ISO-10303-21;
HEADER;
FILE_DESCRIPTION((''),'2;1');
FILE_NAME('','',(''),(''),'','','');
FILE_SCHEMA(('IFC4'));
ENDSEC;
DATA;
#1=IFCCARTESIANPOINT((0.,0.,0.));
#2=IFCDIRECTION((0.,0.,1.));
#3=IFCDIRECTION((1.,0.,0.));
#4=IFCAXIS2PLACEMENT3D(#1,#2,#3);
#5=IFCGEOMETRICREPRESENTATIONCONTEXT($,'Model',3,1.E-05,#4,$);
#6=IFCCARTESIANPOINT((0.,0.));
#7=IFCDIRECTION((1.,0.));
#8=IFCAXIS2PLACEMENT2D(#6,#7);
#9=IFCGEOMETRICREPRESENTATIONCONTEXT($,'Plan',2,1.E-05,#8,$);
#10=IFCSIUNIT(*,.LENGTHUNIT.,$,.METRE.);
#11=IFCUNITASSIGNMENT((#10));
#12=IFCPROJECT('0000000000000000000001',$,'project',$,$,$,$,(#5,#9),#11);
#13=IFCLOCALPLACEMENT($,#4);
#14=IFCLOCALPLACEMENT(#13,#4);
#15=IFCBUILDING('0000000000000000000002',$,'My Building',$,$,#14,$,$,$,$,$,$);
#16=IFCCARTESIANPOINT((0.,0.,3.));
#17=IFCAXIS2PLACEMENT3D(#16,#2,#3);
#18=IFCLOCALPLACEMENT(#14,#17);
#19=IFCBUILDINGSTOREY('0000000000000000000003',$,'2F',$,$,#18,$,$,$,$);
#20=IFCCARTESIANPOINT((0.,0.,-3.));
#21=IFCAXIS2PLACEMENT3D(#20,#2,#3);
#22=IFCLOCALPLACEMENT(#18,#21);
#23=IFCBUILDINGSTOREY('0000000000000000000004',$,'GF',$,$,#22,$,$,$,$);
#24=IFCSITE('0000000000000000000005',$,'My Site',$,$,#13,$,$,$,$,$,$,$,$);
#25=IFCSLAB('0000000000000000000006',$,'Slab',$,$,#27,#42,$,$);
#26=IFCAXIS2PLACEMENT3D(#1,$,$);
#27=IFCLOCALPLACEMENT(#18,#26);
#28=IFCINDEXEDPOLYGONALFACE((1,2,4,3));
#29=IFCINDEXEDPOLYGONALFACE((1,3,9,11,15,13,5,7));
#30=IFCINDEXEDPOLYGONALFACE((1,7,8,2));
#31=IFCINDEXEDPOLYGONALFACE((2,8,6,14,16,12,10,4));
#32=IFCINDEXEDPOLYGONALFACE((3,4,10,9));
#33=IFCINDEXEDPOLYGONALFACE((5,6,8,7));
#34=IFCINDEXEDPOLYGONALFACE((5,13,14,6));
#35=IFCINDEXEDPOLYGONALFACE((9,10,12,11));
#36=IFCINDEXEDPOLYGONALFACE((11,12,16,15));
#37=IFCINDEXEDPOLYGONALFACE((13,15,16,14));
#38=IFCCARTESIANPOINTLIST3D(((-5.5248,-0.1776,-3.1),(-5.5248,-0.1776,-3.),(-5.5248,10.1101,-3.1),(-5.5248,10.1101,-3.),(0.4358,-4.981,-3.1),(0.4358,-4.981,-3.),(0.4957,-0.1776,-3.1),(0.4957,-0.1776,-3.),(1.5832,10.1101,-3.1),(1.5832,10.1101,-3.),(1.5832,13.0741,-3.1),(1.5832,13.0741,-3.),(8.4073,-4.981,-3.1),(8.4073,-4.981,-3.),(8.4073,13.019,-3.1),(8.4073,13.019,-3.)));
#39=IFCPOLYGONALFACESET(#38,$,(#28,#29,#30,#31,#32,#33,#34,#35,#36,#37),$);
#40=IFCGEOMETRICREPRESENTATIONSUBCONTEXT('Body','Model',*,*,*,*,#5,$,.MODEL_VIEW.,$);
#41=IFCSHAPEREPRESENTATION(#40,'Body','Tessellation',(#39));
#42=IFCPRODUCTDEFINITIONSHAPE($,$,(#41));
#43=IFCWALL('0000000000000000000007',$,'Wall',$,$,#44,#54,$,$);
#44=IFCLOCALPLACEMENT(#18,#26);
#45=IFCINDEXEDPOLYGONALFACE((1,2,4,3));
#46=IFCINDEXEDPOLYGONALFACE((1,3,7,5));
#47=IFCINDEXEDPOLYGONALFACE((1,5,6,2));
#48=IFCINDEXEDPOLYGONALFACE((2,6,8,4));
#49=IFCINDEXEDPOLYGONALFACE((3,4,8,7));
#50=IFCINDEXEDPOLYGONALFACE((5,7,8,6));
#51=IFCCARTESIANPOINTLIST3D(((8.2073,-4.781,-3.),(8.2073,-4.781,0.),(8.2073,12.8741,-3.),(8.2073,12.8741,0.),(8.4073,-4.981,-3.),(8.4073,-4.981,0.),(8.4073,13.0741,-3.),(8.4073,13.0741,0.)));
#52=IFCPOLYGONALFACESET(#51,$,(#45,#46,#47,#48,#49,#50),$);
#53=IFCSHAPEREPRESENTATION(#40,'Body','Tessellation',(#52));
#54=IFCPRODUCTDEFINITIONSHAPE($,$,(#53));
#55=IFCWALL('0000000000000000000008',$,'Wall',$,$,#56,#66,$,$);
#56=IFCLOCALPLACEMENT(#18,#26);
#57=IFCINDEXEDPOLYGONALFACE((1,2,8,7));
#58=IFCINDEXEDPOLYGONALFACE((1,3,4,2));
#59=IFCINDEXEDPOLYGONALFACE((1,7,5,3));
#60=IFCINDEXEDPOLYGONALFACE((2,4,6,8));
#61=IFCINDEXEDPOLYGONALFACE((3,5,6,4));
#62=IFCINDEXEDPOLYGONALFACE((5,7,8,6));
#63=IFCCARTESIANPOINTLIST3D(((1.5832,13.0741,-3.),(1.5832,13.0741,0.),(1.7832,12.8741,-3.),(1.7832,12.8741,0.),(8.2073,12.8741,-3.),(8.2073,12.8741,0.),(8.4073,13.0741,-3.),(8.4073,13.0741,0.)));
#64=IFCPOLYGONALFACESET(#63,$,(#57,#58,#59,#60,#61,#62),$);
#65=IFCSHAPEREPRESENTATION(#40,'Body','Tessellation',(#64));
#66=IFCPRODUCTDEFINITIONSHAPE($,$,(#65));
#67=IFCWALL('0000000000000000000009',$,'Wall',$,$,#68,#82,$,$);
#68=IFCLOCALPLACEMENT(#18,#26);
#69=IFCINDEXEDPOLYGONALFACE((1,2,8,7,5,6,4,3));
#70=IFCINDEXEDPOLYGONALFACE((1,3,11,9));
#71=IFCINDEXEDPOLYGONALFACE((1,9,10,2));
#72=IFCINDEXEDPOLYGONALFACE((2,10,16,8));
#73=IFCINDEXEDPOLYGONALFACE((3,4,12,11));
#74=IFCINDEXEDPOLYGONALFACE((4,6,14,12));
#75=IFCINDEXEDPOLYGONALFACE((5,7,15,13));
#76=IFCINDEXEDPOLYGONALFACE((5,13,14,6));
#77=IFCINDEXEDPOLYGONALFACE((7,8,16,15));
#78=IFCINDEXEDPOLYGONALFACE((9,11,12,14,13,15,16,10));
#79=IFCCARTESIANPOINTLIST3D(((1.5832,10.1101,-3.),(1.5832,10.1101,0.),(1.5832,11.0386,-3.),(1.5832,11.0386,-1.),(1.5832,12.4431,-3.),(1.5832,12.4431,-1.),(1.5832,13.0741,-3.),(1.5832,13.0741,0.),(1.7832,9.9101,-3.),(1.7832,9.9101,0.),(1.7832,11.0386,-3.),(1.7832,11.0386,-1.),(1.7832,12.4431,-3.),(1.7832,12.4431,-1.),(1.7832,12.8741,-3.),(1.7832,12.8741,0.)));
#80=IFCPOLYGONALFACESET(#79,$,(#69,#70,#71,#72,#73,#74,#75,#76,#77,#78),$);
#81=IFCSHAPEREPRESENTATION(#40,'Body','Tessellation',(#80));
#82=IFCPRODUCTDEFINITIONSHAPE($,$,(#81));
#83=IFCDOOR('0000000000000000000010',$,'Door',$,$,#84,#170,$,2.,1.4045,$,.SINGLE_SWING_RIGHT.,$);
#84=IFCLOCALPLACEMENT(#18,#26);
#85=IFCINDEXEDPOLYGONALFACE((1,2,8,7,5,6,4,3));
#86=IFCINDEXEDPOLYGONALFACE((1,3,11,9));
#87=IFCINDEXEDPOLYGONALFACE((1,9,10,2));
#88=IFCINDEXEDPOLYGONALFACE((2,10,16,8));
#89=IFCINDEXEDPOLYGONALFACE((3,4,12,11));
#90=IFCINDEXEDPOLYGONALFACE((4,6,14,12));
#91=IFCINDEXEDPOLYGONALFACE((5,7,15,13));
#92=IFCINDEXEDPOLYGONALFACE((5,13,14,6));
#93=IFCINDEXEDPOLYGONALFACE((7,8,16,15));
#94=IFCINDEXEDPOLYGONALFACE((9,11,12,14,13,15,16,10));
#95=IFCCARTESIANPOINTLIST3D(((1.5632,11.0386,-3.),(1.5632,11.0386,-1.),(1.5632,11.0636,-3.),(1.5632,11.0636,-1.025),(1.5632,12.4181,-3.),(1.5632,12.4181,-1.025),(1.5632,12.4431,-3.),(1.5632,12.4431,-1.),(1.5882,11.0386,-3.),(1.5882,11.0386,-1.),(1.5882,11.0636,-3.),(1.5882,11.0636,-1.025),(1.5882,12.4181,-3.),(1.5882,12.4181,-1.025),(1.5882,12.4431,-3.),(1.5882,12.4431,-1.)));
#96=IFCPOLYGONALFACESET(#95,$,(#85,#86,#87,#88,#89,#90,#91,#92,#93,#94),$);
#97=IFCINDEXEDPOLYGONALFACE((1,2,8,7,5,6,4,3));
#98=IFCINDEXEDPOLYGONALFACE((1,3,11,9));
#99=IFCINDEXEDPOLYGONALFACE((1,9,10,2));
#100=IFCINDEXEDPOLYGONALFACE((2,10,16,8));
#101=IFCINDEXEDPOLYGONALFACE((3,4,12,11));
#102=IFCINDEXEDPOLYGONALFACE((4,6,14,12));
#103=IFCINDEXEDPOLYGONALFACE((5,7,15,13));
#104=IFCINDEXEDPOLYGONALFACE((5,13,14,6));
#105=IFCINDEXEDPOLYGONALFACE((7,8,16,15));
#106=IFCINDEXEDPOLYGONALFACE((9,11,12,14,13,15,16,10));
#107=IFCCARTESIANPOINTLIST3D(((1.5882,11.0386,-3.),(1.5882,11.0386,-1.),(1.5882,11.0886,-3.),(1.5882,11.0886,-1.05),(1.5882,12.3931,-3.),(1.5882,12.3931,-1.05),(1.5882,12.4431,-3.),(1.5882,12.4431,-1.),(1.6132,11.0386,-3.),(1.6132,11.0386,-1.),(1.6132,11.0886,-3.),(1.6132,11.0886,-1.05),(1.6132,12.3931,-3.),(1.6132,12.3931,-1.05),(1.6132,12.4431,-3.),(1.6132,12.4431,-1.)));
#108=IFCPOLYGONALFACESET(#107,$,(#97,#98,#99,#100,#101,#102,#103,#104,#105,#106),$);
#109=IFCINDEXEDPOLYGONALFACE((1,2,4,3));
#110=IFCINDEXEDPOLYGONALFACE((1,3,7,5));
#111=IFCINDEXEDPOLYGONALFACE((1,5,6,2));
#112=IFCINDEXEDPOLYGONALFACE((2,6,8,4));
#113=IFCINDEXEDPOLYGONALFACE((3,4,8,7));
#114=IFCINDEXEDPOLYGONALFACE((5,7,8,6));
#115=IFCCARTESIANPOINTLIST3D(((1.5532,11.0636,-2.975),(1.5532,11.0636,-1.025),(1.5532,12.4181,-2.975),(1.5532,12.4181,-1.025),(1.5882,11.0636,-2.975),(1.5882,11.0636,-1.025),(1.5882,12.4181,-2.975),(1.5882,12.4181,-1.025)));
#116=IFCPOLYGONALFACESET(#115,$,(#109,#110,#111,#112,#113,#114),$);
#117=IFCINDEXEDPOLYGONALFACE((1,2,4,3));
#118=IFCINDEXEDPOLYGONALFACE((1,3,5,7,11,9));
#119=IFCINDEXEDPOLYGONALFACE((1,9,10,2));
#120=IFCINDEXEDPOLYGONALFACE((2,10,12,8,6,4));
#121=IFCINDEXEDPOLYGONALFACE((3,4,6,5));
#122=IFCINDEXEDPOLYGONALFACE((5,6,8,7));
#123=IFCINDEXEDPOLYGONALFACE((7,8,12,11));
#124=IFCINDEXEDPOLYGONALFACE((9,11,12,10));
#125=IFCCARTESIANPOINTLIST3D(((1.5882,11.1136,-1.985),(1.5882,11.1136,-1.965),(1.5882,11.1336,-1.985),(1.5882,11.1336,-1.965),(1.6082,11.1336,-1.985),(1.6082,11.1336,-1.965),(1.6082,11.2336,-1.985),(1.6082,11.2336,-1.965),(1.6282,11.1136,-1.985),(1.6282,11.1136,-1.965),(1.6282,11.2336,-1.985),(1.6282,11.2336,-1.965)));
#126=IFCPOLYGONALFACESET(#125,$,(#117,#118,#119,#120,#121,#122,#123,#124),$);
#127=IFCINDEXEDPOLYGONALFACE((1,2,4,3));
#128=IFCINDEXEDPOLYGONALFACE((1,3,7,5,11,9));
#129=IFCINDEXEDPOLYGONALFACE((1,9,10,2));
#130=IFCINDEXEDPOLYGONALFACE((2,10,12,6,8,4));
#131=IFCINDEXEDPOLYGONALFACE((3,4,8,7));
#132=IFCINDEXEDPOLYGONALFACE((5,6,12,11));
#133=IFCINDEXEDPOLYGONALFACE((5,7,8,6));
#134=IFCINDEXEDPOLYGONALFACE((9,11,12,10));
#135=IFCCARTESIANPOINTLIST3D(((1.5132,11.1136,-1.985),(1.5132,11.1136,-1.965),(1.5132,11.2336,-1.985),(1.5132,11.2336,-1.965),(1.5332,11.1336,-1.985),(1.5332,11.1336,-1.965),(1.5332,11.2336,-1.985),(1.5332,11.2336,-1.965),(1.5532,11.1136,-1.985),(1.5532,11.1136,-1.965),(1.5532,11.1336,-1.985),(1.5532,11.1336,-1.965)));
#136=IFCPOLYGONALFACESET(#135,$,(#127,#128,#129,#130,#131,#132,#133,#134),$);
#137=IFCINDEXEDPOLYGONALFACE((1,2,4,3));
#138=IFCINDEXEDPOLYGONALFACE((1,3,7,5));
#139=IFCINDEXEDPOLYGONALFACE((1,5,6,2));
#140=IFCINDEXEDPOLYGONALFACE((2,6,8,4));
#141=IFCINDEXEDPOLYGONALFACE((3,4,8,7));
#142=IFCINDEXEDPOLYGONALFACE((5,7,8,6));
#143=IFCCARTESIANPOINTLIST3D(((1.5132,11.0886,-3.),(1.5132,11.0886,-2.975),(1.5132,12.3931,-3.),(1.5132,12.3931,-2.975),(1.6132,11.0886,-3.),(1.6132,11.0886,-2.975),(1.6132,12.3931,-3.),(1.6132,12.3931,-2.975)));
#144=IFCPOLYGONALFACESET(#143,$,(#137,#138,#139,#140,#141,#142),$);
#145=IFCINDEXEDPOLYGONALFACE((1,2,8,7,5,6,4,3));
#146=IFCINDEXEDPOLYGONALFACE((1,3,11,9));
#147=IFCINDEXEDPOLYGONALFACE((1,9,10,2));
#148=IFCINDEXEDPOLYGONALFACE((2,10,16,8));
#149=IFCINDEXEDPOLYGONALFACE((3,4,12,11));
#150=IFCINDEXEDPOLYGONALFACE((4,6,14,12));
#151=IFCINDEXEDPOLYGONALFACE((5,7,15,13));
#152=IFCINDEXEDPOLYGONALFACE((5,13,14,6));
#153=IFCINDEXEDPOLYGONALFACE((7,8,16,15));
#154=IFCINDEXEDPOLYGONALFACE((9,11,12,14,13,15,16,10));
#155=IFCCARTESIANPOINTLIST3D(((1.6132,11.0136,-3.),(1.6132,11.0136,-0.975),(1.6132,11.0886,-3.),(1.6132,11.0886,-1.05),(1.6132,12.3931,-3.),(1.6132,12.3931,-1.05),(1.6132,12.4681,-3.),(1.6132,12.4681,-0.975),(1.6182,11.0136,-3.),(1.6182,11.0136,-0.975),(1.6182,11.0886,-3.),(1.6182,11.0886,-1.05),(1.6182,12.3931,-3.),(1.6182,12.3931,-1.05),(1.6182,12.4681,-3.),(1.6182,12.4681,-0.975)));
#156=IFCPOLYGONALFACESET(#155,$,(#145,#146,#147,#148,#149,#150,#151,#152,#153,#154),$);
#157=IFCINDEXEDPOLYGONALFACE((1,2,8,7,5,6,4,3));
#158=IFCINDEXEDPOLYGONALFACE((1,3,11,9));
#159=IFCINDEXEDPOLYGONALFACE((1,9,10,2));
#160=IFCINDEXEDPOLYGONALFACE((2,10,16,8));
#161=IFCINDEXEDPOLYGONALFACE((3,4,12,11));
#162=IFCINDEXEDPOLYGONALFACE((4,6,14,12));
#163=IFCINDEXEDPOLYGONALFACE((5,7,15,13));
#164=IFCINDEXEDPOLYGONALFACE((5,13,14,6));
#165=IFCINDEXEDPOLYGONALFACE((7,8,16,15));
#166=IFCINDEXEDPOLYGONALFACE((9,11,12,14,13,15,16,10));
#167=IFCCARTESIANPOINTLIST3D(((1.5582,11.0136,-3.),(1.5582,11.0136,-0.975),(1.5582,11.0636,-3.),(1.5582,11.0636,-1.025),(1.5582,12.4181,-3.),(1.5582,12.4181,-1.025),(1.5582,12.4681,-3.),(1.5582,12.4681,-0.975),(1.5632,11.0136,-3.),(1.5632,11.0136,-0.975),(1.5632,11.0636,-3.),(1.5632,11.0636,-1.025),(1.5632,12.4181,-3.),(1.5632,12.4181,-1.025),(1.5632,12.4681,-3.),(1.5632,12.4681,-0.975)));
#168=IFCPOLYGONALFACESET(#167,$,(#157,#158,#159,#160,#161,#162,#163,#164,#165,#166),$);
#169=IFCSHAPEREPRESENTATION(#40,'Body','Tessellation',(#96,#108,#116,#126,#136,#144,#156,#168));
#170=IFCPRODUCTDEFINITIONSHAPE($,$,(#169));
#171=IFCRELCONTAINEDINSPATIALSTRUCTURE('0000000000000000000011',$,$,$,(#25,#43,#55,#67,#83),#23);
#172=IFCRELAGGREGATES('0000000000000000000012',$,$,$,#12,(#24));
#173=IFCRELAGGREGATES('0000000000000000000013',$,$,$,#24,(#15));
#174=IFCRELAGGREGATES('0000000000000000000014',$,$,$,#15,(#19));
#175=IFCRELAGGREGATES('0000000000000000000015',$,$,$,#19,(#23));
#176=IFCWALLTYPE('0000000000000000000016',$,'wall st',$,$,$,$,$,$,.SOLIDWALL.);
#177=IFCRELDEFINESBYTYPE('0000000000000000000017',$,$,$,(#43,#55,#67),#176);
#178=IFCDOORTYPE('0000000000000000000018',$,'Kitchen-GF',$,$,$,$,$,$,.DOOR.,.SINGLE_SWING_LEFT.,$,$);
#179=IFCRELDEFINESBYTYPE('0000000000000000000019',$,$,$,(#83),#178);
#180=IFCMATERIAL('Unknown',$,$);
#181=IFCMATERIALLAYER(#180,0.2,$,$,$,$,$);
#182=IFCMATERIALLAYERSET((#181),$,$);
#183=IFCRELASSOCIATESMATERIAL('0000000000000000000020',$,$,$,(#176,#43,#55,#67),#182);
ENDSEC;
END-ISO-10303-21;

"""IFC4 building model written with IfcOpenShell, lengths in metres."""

from ifc_helpers import new_model, entity, si_unit, frame, origin_with_axes, origin_2d_with_axis, place, context, subcontext, project, spatial, line, indexed_curve, outline, extrude, shape, source, transform, mapped, material, layer, layer_set, layer_usage, type_object, type_shapes, element, fill, save


model = new_model("IFC4")

# Units and contexts
model_context = context("Model", 3, precision=1e-05, world=origin_with_axes())
plan_context = context("Plan", 2, precision=1e-05, world=origin_2d_with_axis())
body_context_1 = subcontext(model_context, "Body", "Model", "MODEL_VIEW")
body_context_2 = subcontext(plan_context, "Body", "Plan", "PLAN_VIEW")
ifc_project = project(units=[si_unit("LENGTHUNIT", "METRE")], contexts=[model_context, plan_context])

# Site, building, storeys
site_placement = place(None, origin_with_axes())
site = spatial("IfcSite", under=ifc_project, at=site_placement, Name="My Site")
building_placement = place(site_placement, origin_with_axes())
building = spatial("IfcBuilding", under=site, at=building_placement, Name="My Building")
storey_1_placement = place(building_placement, frame((0.0, 0.0, 3.0), z_axis=(0.0, 0.0, 1.0), x_axis=(1.0, 0.0, 0.0)))
storey_1 = spatial("IfcBuildingStorey", under=building, at=storey_1_placement, Name="2F")
storey_2_placement = place(storey_1_placement, frame((0.0, 0.0, -3.0), z_axis=(0.0, 0.0, 1.0), x_axis=(1.0, 0.0, 0.0)))
storey_2 = spatial("IfcBuildingStorey", under=storey_1, at=storey_2_placement, Name="GF")

# Slab
ifc_material = material(Name="Unknown")
slab_1_placement = place(storey_2_placement, frame((8.4073, -4.981, 0.0), z_axis=(0.0, 0.0, 1.0), x_axis=(1.0, 0.0, 0.0)))
element("IfcSlab", 1, at=slab_1_placement, inside=storey_2, Name="Slab", context=body_context_1, shape_type="SweptSolid", body=[
    extrude(outline(indexed_curve([(0.0, 0.0), (0.0, 18.0), (-6.8241, 18.055), (-6.8241, 15.091), (-13.9321, 15.091), (-13.9321, 4.8033), (-7.9116, 4.8033), (-7.9715, 0.0), (0.0, 0.0)])), frame((0.0, 0.0, -0.1), z_axis=(0.0, 0.0, 1.0), x_axis=(1.0, 0.0, 0.0)), (0.0, 0.0, 1.0), 0.1),
])

# Shared definitions
ifc_layer_1 = layer(ifc_material, 0.2)
ifc_layer_set_1 = layer_set([ifc_layer_1])
wall_type = type_object("IfcWallType", Name="wall st", PredefinedType="SOLIDWALL", material=ifc_layer_set_1)

# Walls
ifc_layer_usage_1 = layer_usage(ifc_layer_set_1, "AXIS2", "POSITIVE", 0.0)
wall_1_placement = place(storey_2_placement, frame((8.4073, -4.981, 0.0), z_axis=(0.0, 0.0, 1.0), x_axis=(0.0, 1.0, 0.0)))
element("IfcWall", 2, at=wall_1_placement, inside=storey_2, type_object=wall_type, material=ifc_layer_usage_1, Name="Wall", context=body_context_1, shape_type="SweptSolid", body=[
    extrude(outline(indexed_curve([(0.0, 0.0), (0.2, 0.2), (17.855, 0.2), (18.055, 0.0)], segments=[line(1, 2, 3, 4, 1)])), origin_with_axes(), (0.0, 0.0, 1.0), 3.0),
])
ifc_layer_usage_2 = layer_usage(ifc_layer_set_1, "AXIS2", "POSITIVE", 0.0)
wall_2_placement = place(storey_2_placement, frame((8.4073, 13.0741, 0.0), z_axis=(0.0, 0.0, 1.0), x_axis=(-1.0, 0.0, 0.0)))
element("IfcWall", 3, at=wall_2_placement, inside=storey_2, type_object=wall_type, material=ifc_layer_usage_2, Name="Wall", context=body_context_1, shape_type="SweptSolid", body=[
    extrude(outline(indexed_curve([(0.0, 0.0), (0.2, 0.2), (6.6241, 0.2), (6.8241, 0.0)], segments=[line(1, 2, 3, 4, 1)])), origin_with_axes(), (0.0, 0.0, 1.0), 3.0),
])

# Wall, opening, door
ifc_layer_usage_3 = layer_usage(ifc_layer_set_1, "AXIS2", "POSITIVE", 0.0)
wall_3_placement = place(storey_2_placement, frame((1.5832, 13.0741, 0.0), z_axis=(0.0, 0.0, 1.0), x_axis=(0.0, -1.0, 0.0)))
wall_3 = element("IfcWall", 4, at=wall_3_placement, inside=storey_2, type_object=wall_type, material=ifc_layer_usage_3, Name="Wall", context=body_context_1, shape_type="SweptSolid", body=[
    extrude(outline(indexed_curve([(0.0, 0.0), (0.2, 0.2), (3.164, 0.2), (2.964, 0.0)], segments=[line(1, 2, 3, 4, 1)])), origin_with_axes(), (0.0, 0.0, 1.0), 3.0),
])
shared_shape_1 = source(origin_with_axes(), body_context_1, "Body", "SweptSolid", [
    extrude(outline(indexed_curve([(0.0, 0.0), (1.4045, 0.0), (1.4045, 2.0), (0.0, 2.0)], segments=[line(1, 2, 3, 4, 1)])), frame((0.0, -0.6, 0.0), z_axis=(0.0, -1.0, 0.0), x_axis=(1.0, 0.0, 0.0)), (0.0, 0.0, -1.0), 1.2),
])
opening_1_placement = place(wall_3_placement, frame((2.0355, 0.03, 0.0), z_axis=(0.0, 0.0, 1.0), x_axis=(-1.0, 0.0, 0.0)))
opening_1 = element("IfcOpeningElement", 5, at=opening_1_placement, cuts=wall_3, PredefinedType="OPENING", context=body_context_1, shape_type="MappedRepresentation", body=[
    mapped(shared_shape_1, transform((0.0, 0.0, 0.0), x_axis=(1.0, 0.0, 0.0), y_axis=(0.0, 1.0, 0.0), z_axis=(0.0, 0.0, 1.0), scale=1.0)),
])
door_type_1 = type_object("IfcDoorType", Name="Kitchen-GF", OperationType="SINGLE_SWING_LEFT", PredefinedType="DOOR")
shared_shape_2 = source(origin_with_axes(), body_context_1, "Body", "SweptSolid", [
    extrude(outline(indexed_curve([(0.0, 0.0), (0.0, 2.0), (1.4045, 2.0), (1.4045, 0.0), (1.3795, 0.0), (1.3795, 1.975), (0.025, 1.975), (0.025, 0.0)], segments=[line(1, 2, 3, 4, 5, 6, 7, 8, 1)])), frame((0.0, 0.025, 0.0), z_axis=(0.0, -1.0, 0.0), x_axis=(1.0, 0.0, 0.0)), (0.0, 0.0, -1.0), 0.025),
    extrude(outline(indexed_curve([(0.0, 0.0), (0.0, 2.0), (1.4045, 2.0), (1.4045, 0.0), (1.3545, 0.0), (1.3545, 1.95), (0.05, 1.95), (0.05, 0.0)], segments=[line(1, 2, 3, 4, 5, 6, 7, 8, 1)])), frame((0.0, 0.0, 0.0), z_axis=(0.0, -1.0, 0.0), x_axis=(1.0, 0.0, 0.0)), (0.0, 0.0, -1.0), 0.025),
    extrude(outline(indexed_curve([(0.0, 0.0), (1.3545, 0.0), (1.3545, 0.035), (0.0, 0.035)], segments=[line(1, 2, 3, 4, 1)])), frame((0.025, 0.025, 0.025), z_axis=(0.0, 0.0, 1.0), x_axis=(1.0, 0.0, 0.0)), (0.0, 0.0, 1.0), 1.95),
    extrude(outline(indexed_curve([(0.0, 0.0), (0.0, -0.04), (0.12, -0.04), (0.12, -0.02), (0.02, -0.02), (0.02, 0.0)], segments=[line(1, 2, 3, 4, 5, 6, 1)])), frame((0.075, 0.025, 1.015), z_axis=(0.0, 0.0, 1.0), x_axis=(1.0, 0.0, 0.0)), (0.0, 0.0, 1.0), 0.02),
    extrude(outline(indexed_curve([(0.0, 0.0), (0.0, 0.04), (0.12, 0.04), (0.12, 0.02), (0.02, 0.02), (0.02, 0.0)], segments=[line(1, 2, 3, 4, 5, 6, 1)])), frame((0.075, 0.06, 1.015), z_axis=(0.0, 0.0, 1.0), x_axis=(1.0, 0.0, 0.0)), (0.0, 0.0, 1.0), 0.02),
    extrude(outline(indexed_curve([(0.0, 0.0), (1.3045, 0.0), (1.3045, 0.1), (0.0, 0.1)], segments=[line(1, 2, 3, 4, 1)])), frame((0.05, 0.0, 0.0), z_axis=(0.0, 0.0, 1.0), x_axis=(1.0, 0.0, 0.0)), (0.0, 0.0, 1.0), 0.025),
    extrude(outline(indexed_curve([(0.0, 0.0), (0.0, 2.025), (1.4545, 2.025), (1.4545, 0.0), (1.3795, 0.0), (1.3795, 1.95), (0.075, 1.95), (0.075, 0.0)], segments=[line(1, 2, 3, 4, 5, 6, 7, 8, 1)])), frame((-0.025, -0.005, 0.0), z_axis=(0.0, -1.0, 0.0), x_axis=(1.0, 0.0, 0.0)), (0.0, 0.0, -1.0), 0.005),
    extrude(outline(indexed_curve([(0.0, 0.0), (0.0, 2.025), (1.4545, 2.025), (1.4545, 0.0), (1.4045, 0.0), (1.4045, 1.975), (0.05, 1.975), (0.05, 0.0)], segments=[line(1, 2, 3, 4, 5, 6, 7, 8, 1)])), frame((-0.025, 0.05, 0.0), z_axis=(0.0, -1.0, 0.0), x_axis=(1.0, 0.0, 0.0)), (0.0, 0.0, -1.0), 0.005),
])
shared_shape_3 = source(origin_with_axes(), body_context_2, "Body", "Curve2D", [
    entity("IfcIndexedPolyCurve", entity("IfcCartesianPointList2D", [[0.0, 0.0], [0.0, 0.05], [0.025, 0.05], [0.025, 0.025], [0.05, 0.025], [0.05, 0.0]]), [entity("IfcLineIndex", [1, 2, 3, 4, 5, 6, 1])]),
    entity("IfcIndexedPolyCurve", entity("IfcCartesianPointList2D", [[1.4045, 0.0], [1.4045, 0.05], [1.3795, 0.05], [1.3795, 0.025], [1.3545, 0.025], [1.3545, 0.0]]), [entity("IfcLineIndex", [1, 2, 3, 4, 5, 6, 1])]),
    entity("IfcTrimmedCurve", entity("IfcEllipse", entity("IfcAxis2Placement2D", entity("IfcCartesianPoint", [1.3445, 0.05]), entity("IfcDirection", [1.0, 0.0])), 1.3195, 1.3545), [entity("IfcCartesianPoint", [1.3445, 1.4045])], [entity("IfcCartesianPoint", [0.025, 0.05])], True, "CARTESIAN"),
    entity("IfcIndexedPolyCurve", entity("IfcCartesianPointList2D", [[1.3795, 0.05], [1.3445, 0.05], [1.3445, 1.4045], [1.3795, 1.4045]]), [entity("IfcLineIndex", [1, 2, 3, 4, 1])]),
])
type_shapes(door_type_1, [shared_shape_2, shared_shape_3])
door_1_placement = place(opening_1_placement, frame((0.0, 0.0, 0.0), z_axis=(0.0, 0.0, 1.0), x_axis=(1.0, 0.0, 0.0)))
door_1 = element("IfcDoor", 6, at=door_1_placement, inside=storey_2, type_object=door_type_1, Name="Door", OperationType="SINGLE_SWING_RIGHT", OverallHeight=2.0, OverallWidth=1.4045, shapes=[
    shape(body_context_1, "Body", "MappedRepresentation", [mapped(shared_shape_2, transform((0.0, 0.0, 0.0), x_axis=(1.0, 0.0, 0.0), y_axis=(0.0, 1.0, 0.0), z_axis=(0.0, 0.0, 1.0), scale=1.0))]),
    shape(body_context_2, "Body", "MappedRepresentation", [mapped(shared_shape_3, transform((0.0, 0.0, 0.0), x_axis=(1.0, 0.0, 0.0), y_axis=(0.0, 1.0, 0.0), z_axis=(0.0, 0.0, 1.0), scale=1.0))]),
])
fill(opening_1, door_1)

save(model, "model.ifc")
